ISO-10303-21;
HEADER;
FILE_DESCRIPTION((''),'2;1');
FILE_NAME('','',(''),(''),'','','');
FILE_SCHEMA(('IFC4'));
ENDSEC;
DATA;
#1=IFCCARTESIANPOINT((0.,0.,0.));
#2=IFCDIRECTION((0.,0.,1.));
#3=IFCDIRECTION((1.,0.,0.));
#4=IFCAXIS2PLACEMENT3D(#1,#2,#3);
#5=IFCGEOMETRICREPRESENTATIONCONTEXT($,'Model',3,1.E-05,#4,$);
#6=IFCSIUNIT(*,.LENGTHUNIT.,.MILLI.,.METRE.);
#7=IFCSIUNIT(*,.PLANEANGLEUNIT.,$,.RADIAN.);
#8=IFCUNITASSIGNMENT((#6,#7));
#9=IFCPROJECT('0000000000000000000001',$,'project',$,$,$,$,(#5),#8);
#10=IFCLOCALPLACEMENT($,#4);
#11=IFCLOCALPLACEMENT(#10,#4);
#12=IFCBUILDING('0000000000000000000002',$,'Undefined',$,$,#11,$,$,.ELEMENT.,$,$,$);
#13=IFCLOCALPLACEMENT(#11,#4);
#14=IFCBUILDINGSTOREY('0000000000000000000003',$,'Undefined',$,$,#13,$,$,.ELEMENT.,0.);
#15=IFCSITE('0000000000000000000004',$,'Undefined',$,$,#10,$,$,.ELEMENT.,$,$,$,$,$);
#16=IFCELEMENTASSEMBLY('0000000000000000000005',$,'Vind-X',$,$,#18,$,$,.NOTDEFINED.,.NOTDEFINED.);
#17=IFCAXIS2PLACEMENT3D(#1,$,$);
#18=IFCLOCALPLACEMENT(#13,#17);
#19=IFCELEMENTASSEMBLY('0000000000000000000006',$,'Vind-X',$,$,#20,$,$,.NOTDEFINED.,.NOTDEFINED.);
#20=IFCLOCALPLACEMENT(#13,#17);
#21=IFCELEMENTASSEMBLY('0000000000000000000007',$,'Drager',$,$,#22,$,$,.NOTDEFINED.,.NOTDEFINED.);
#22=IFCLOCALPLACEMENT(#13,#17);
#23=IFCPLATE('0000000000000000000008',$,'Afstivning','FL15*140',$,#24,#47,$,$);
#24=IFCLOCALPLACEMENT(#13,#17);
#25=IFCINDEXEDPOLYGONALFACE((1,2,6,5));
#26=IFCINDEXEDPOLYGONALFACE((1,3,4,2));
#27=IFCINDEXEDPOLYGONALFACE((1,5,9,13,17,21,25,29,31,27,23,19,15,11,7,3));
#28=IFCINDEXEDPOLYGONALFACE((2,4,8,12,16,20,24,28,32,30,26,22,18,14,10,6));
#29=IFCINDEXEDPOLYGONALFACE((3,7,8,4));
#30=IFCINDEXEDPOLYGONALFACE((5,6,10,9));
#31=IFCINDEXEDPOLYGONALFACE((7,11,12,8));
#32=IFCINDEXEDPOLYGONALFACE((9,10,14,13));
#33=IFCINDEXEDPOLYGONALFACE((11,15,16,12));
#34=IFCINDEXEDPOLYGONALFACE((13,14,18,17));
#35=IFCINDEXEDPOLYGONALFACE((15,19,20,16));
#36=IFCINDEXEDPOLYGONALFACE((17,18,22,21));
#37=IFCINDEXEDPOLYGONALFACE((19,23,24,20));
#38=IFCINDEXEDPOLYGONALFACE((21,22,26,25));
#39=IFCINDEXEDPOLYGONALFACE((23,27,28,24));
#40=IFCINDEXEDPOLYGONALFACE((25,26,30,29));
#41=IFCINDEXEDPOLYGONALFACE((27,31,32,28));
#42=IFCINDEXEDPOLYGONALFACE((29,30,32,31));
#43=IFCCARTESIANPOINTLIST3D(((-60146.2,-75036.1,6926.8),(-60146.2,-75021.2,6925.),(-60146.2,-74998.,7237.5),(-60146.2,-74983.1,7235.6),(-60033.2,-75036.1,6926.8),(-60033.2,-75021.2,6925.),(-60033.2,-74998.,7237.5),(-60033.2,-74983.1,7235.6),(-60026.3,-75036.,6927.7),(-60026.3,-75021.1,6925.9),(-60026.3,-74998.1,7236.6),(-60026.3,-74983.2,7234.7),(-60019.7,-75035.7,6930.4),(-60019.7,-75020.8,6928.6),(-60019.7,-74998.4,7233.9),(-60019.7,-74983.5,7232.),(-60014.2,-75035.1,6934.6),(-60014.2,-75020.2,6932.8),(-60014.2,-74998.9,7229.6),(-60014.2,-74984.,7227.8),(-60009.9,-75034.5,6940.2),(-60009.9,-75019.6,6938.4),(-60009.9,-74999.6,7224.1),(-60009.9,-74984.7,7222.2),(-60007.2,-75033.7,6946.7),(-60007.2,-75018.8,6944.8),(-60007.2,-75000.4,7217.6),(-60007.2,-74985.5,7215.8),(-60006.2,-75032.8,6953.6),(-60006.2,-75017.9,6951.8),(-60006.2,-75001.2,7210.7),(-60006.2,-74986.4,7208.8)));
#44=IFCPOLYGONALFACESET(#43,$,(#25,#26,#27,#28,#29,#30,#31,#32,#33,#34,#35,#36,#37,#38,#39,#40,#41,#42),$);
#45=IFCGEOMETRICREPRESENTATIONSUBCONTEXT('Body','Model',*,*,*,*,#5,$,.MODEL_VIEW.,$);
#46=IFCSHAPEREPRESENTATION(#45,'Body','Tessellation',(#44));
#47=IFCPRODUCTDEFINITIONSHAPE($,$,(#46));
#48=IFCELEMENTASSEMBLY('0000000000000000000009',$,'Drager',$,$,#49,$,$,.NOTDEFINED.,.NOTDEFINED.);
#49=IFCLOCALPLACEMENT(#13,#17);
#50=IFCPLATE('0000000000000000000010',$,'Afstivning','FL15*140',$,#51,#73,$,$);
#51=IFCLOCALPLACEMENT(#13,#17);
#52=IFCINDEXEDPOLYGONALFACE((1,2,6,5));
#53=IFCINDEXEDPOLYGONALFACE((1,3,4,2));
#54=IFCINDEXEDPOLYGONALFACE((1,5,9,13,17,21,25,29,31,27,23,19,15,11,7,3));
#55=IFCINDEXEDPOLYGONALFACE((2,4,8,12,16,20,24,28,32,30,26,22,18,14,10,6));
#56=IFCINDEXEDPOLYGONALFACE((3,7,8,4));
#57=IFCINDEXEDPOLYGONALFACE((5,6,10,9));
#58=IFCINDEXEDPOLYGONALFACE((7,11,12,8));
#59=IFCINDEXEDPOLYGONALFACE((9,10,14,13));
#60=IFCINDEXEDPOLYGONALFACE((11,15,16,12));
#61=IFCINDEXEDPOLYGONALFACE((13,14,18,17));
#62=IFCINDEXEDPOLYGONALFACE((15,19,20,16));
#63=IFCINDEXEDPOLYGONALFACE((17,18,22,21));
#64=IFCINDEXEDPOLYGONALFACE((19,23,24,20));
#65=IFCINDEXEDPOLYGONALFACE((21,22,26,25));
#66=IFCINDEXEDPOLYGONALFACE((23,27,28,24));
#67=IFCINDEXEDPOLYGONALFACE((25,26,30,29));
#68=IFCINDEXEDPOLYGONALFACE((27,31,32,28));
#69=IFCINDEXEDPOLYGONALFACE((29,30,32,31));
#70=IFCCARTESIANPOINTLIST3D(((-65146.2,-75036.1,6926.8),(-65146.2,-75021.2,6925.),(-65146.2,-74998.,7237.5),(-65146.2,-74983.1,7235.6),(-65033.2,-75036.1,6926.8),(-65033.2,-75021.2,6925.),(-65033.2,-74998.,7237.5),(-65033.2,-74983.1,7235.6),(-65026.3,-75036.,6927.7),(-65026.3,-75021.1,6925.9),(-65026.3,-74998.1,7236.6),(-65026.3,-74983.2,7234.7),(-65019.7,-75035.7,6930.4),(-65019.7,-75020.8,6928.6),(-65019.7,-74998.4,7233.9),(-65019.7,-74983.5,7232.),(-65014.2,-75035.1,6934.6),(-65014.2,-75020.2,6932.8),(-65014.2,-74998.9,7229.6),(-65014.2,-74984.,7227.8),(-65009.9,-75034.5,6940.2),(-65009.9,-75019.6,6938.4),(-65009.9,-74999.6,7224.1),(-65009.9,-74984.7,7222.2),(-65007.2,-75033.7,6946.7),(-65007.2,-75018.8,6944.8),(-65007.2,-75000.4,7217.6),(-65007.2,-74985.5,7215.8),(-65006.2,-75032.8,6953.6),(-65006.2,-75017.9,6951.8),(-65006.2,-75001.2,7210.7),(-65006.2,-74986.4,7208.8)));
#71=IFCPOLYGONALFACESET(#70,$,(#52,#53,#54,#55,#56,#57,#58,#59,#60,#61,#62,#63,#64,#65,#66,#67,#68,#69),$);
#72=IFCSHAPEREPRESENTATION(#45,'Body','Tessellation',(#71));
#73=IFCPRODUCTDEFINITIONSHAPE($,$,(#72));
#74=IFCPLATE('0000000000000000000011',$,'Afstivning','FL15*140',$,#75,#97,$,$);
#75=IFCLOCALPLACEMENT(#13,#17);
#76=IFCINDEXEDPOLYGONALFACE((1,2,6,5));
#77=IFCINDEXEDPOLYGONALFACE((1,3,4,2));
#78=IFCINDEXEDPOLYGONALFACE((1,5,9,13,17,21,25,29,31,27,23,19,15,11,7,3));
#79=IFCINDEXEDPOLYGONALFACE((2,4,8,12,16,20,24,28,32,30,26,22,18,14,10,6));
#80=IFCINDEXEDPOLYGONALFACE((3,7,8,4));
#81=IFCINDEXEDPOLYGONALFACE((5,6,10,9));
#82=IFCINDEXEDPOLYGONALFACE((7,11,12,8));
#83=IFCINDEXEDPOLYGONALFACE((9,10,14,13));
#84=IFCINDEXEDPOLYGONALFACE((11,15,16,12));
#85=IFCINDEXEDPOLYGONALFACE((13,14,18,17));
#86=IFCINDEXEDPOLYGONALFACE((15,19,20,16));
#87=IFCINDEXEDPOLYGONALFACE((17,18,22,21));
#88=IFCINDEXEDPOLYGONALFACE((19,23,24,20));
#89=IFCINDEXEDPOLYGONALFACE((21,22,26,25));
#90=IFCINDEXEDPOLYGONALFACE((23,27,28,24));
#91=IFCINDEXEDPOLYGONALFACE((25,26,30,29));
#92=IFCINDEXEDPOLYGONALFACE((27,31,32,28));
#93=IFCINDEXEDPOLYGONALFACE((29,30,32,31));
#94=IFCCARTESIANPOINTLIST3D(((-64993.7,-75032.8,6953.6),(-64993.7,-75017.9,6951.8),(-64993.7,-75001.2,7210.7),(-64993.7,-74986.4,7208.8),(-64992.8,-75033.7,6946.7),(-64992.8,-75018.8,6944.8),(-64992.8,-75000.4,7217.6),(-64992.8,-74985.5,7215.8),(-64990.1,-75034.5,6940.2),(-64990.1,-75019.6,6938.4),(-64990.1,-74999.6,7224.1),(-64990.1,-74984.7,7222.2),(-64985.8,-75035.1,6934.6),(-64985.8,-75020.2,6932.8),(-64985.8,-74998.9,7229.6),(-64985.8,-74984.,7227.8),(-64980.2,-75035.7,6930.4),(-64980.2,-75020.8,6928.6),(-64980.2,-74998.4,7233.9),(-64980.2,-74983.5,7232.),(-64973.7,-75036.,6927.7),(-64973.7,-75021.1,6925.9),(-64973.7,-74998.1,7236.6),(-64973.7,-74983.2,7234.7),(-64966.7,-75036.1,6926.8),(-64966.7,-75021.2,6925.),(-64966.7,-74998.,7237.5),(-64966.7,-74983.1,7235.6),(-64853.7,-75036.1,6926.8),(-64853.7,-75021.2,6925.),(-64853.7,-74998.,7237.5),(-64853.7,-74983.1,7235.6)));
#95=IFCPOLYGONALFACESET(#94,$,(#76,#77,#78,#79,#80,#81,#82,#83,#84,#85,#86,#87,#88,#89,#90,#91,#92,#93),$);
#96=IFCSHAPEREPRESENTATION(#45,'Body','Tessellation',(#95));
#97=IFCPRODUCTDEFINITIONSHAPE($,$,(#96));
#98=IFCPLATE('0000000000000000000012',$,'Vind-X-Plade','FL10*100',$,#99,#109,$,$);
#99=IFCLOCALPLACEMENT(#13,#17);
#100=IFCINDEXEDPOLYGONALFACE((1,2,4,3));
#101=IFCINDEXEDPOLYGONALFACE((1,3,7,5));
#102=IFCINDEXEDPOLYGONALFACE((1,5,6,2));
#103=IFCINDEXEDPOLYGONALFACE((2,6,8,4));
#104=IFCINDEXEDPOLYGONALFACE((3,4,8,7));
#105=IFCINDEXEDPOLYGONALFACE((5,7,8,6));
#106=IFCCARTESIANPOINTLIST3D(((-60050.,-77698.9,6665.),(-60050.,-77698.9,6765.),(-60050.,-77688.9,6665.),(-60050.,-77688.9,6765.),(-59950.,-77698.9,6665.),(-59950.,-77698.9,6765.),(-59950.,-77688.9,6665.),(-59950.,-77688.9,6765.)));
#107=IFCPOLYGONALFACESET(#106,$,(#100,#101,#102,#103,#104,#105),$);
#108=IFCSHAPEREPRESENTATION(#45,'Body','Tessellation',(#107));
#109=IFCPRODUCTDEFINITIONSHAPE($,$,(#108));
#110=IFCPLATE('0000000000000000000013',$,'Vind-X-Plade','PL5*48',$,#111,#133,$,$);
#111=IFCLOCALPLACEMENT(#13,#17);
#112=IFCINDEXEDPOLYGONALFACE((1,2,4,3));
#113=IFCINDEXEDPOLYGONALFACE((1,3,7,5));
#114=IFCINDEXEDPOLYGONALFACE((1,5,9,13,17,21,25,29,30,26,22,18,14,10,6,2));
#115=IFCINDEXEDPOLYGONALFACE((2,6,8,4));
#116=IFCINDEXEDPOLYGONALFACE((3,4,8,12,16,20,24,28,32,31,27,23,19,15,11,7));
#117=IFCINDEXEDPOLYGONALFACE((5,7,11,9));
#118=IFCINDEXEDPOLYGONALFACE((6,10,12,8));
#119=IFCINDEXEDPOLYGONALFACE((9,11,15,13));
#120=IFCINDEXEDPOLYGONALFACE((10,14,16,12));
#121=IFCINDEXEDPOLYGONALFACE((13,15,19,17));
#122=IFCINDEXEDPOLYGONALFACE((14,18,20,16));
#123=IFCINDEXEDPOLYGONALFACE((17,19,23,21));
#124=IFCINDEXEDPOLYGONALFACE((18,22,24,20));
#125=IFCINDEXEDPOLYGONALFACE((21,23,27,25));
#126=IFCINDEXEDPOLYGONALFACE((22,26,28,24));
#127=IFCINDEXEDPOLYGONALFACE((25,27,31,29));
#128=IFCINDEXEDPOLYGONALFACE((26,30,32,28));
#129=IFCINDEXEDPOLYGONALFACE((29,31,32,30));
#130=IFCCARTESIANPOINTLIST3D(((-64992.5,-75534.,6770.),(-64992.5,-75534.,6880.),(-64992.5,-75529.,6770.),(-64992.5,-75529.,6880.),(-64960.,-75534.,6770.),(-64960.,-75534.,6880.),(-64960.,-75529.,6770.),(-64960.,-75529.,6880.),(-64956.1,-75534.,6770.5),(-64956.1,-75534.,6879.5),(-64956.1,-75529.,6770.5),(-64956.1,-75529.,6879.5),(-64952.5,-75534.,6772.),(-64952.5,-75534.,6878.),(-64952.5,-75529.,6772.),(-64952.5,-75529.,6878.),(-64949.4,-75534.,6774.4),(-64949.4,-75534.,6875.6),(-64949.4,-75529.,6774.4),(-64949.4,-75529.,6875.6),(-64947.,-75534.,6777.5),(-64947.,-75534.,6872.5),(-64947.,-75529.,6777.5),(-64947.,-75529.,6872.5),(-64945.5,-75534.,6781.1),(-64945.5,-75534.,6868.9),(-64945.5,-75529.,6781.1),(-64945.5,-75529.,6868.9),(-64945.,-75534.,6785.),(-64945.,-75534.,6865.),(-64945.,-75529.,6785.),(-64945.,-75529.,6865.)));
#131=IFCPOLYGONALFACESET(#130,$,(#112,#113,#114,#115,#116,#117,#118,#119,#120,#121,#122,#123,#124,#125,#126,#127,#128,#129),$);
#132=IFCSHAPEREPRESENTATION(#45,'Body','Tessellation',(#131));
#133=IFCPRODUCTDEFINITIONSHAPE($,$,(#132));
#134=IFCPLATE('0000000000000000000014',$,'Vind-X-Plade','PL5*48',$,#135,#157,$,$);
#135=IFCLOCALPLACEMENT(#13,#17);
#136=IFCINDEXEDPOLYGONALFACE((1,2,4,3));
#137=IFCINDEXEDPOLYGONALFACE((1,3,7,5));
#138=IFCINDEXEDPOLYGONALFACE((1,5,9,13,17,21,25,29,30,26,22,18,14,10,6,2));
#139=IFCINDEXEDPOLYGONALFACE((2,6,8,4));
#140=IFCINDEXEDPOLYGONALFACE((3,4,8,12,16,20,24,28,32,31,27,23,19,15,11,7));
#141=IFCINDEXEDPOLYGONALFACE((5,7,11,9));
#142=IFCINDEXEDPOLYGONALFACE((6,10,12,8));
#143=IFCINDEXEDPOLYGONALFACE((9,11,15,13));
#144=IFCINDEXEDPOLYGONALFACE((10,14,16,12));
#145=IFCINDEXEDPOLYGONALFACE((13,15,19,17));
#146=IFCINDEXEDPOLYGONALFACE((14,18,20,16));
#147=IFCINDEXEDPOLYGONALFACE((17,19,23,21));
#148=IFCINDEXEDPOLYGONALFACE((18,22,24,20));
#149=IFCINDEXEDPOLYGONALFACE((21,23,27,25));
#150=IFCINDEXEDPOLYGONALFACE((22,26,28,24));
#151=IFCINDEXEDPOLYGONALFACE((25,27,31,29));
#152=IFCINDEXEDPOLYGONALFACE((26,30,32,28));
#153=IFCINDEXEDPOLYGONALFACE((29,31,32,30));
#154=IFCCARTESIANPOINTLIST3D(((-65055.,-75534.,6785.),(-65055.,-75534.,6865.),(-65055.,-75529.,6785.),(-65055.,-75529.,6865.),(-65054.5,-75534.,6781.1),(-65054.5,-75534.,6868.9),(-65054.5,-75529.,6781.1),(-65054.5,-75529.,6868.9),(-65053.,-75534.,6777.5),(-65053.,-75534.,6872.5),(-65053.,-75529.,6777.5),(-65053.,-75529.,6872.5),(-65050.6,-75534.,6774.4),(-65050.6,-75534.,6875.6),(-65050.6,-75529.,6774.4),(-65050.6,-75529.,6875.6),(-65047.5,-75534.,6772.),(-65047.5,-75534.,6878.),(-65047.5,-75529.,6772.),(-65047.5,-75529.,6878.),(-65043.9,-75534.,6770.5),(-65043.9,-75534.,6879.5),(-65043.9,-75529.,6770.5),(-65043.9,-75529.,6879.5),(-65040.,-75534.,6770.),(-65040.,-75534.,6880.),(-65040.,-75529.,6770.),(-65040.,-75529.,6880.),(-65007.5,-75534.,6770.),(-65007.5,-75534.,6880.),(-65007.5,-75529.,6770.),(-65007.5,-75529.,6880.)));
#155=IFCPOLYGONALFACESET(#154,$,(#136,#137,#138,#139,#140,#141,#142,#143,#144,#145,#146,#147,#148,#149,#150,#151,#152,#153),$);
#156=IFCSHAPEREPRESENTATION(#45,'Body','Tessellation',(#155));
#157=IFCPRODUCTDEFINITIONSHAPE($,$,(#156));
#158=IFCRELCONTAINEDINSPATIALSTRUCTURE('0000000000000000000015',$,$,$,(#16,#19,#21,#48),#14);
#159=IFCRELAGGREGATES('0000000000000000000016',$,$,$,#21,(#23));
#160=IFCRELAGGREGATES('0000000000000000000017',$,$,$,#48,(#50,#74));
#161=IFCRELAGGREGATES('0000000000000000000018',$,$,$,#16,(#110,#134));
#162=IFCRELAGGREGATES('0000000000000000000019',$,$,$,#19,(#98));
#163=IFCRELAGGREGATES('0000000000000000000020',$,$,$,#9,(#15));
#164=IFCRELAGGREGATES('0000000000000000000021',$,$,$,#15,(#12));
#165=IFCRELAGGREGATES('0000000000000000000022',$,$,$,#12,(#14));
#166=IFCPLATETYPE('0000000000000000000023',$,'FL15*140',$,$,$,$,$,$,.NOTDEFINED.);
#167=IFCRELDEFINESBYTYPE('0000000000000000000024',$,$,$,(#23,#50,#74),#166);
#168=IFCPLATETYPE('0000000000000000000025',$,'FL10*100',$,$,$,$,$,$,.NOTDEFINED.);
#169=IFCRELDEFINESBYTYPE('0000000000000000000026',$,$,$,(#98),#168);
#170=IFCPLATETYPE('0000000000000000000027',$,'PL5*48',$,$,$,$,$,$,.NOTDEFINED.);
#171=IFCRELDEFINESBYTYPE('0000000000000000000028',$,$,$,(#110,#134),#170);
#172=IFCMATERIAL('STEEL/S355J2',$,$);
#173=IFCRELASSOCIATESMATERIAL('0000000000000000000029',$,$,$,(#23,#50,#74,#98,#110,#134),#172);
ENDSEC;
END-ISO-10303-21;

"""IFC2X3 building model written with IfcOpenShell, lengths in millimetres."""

from ifc_helpers import new_model, si_unit, frame, frame_2d, origin_with_axes, place, context, subcontext, project, spatial, polyline, circle_curve, parameter, trimmed, segment, composite_curve, outline, extrude, material, type_object, element, aggregate, save


model = new_model("IFC2X3")

# Units and contexts
model_context = context("Model", 3, precision=1e-05, world=origin_with_axes())
body_context = subcontext(model_context, "Body", "Model", "MODEL_VIEW")
ifc_project = project(units=[si_unit("LENGTHUNIT", "METRE", prefix="MILLI"), si_unit("PLANEANGLEUNIT", "RADIAN")], contexts=[model_context])

# Site, building, storey
site_placement = place(None, origin_with_axes())
site = spatial("IfcSite", under=ifc_project, at=site_placement, Name="Undefined", CompositionType="ELEMENT")
building_placement = place(site_placement, origin_with_axes())
building = spatial("IfcBuilding", under=site, at=building_placement, Name="Undefined", CompositionType="ELEMENT")
storey_placement = place(building_placement, origin_with_axes())
storey = spatial("IfcBuildingStorey", under=building, at=storey_placement, Name="Undefined", CompositionType="ELEMENT", Elevation=0.0)

# Element assemblies
assembly_1_placement = place(storey_placement, origin_with_axes())
assembly_1 = element("IfcElementAssembly", 1, at=assembly_1_placement, inside=storey, Name="Vind-X", AssemblyPlace="NOTDEFINED", PredefinedType="NOTDEFINED")
assembly_2_placement = place(storey_placement, origin_with_axes())
assembly_2 = element("IfcElementAssembly", 2, at=assembly_2_placement, inside=storey, Name="Vind-X", AssemblyPlace="NOTDEFINED", PredefinedType="NOTDEFINED")

# Element assembly, plate
assembly_3_placement = place(storey_placement, origin_with_axes())
assembly_3 = element("IfcElementAssembly", 3, at=assembly_3_placement, inside=storey, Name="Drager", AssemblyPlace="NOTDEFINED", PredefinedType="NOTDEFINED")
ifc_material_1 = material(Name="STEEL/S355J2")
plate_type_1 = type_object("IfcPlateType", Name="FL15*140", PredefinedType="NOTDEFINED")
plate_1_placement = place(assembly_3_placement, frame((-60006.2, -75028.7, 6925.9), z_axis=(0.0, 0.992546, -0.121869), x_axis=(-1.0, 0.0, 0.0)))
plate_1 = element("IfcPlate", 4, at=plate_1_placement, type_object=plate_type_1, material=ifc_material_1, Name="Afstivning", Description="FL15*140", context=body_context, shape_type="SweptSolid", body=[
    extrude(outline(composite_curve([segment(trimmed(circle_curve(frame_2d((27.0, 27.0), x_axis=(-1.0, 0.0)), 27.0), [parameter(0.0)], [parameter(1.570796)], True, "PARAMETER"), True, "CONTINUOUS"), segment(polyline([(27.0, 0.0), (140.0, 0.0), (140.0, 313.0), (27.0, 313.0)]), True, "CONTINUOUS"), segment(trimmed(circle_curve(frame_2d((27.0, 286.0), x_axis=(0.0, 1.0)), 27.0), [parameter(0.0)], [parameter(1.570796)], True, "PARAMETER"), True, "CONTINUOUS"), segment(polyline([(0.0, 286.0), (0.0, 27.0)]), True, "CONTINUOUS")], self_intersect=True)), frame((0.0, 0.0, -7.5), z_axis=(0.0, 0.0, 1.0), x_axis=(1.0, 0.0, 0.0)), (0.0, 0.0, 1.0), 15.0),
])
aggregate(assembly_3, [plate_1])

# Element assembly, plates
assembly_4_placement = place(storey_placement, origin_with_axes())
assembly_4 = element("IfcElementAssembly", 5, at=assembly_4_placement, inside=storey, Name="Drager", AssemblyPlace="NOTDEFINED", PredefinedType="NOTDEFINED")
plate_2_placement = place(assembly_4_placement, frame((-65006.2, -75028.7, 6925.9), z_axis=(0.0, 0.992546, -0.121869), x_axis=(-1.0, 0.0, 0.0)))
plate_2 = element("IfcPlate", 6, at=plate_2_placement, type_object=plate_type_1, material=ifc_material_1, Name="Afstivning", Description="FL15*140", context=body_context, shape_type="SweptSolid", body=[
    extrude(outline(composite_curve([segment(trimmed(circle_curve(frame_2d((27.0, 27.0), x_axis=(-1.0, 0.0)), 27.0), [parameter(0.0)], [parameter(1.570796)], True, "PARAMETER"), True, "CONTINUOUS"), segment(polyline([(27.0, 0.0), (140.0, 0.0), (140.0, 313.0), (27.0, 313.0)]), True, "CONTINUOUS"), segment(trimmed(circle_curve(frame_2d((27.0, 286.0), x_axis=(0.0, 1.0)), 27.0), [parameter(0.0)], [parameter(1.570796)], True, "PARAMETER"), True, "CONTINUOUS"), segment(polyline([(0.0, 286.0), (0.0, 27.0)]), True, "CONTINUOUS")], self_intersect=True)), frame((0.0, 0.0, -7.5), z_axis=(0.0, 0.0, 1.0), x_axis=(1.0, 0.0, 0.0)), (0.0, 0.0, 1.0), 15.0),
])
plate_3_placement = place(assembly_4_placement, frame((-64853.7, -75028.7, 6925.9), z_axis=(0.0, 0.992546, -0.121869), x_axis=(-1.0, 0.0, 0.0)))
plate_3 = element("IfcPlate", 7, at=plate_3_placement, type_object=plate_type_1, material=ifc_material_1, Name="Afstivning", Description="FL15*140", context=body_context, shape_type="SweptSolid", body=[
    extrude(outline(composite_curve([segment(polyline([(0.0, 0.0), (113.0, 0.0)]), True, "CONTINUOUS"), segment(trimmed(circle_curve(frame_2d((113.0, 27.0), x_axis=(0.0, -1.0)), 27.0), [parameter(0.0)], [parameter(1.570796)], True, "PARAMETER"), True, "CONTINUOUS"), segment(polyline([(140.0, 27.0), (140.0, 286.0)]), True, "CONTINUOUS"), segment(trimmed(circle_curve(frame_2d((113.0, 286.0), x_axis=(1.0, 0.0)), 27.0), [parameter(0.0)], [parameter(1.570796)], True, "PARAMETER"), True, "CONTINUOUS"), segment(polyline([(113.0, 313.0), (0.0, 313.0), (0.0, 0.0)]), True, "CONTINUOUS")], self_intersect=True)), frame((0.0, 0.0, -7.5), z_axis=(0.0, 0.0, 1.0), x_axis=(1.0, 0.0, 0.0)), (0.0, 0.0, 1.0), 15.0),
])
aggregate(assembly_4, [plate_2, plate_3])

# Plates
plate_type_2 = type_object("IfcPlateType", Name="FL10*100", PredefinedType="NOTDEFINED")
plate_4_placement = place(assembly_2_placement, frame((-60050.0, -77693.9, 6765.0), z_axis=(0.0, 1.0, 0.0), x_axis=(1.0, 0.0, 0.0)))
plate_4 = element("IfcPlate", 8, at=plate_4_placement, type_object=plate_type_2, material=ifc_material_1, Name="Vind-X-Plade", Description="FL10*100", context=body_context, shape_type="SweptSolid", body=[
    extrude(outline(polyline([(0.0, 0.0), (100.0, 0.0), (100.0, 100.0), (0.0, 100.0), (0.0, 0.0)])), frame((0.0, 0.0, -5.0), z_axis=(0.0, 0.0, 1.0), x_axis=(1.0, 0.0, 0.0)), (0.0, 0.0, 1.0), 10.0),
])
plate_type_3 = type_object("IfcPlateType", Name="PL5*48", PredefinedType="NOTDEFINED")
plate_5_placement = place(assembly_1_placement, frame((-64945.0, -75531.5, 6880.0), z_axis=(0.0, -1.0, 0.0), x_axis=(-1.0, 0.0, 0.0)))
plate_5 = element("IfcPlate", 9, at=plate_5_placement, type_object=plate_type_3, material=ifc_material_1, Name="Vind-X-Plade", Description="PL5*48", context=body_context, shape_type="SweptSolid", body=[
    extrude(outline(composite_curve([segment(trimmed(circle_curve(frame_2d((15.0, 15.0), x_axis=(-1.0, 0.0)), 15.0), [parameter(0.0)], [parameter(1.570796)], True, "PARAMETER"), True, "CONTINUOUS"), segment(polyline([(15.0, 0.0), (47.5, 0.0), (47.5, 110.0), (15.0, 110.0)]), True, "CONTINUOUS"), segment(trimmed(circle_curve(frame_2d((15.0, 95.0), x_axis=(0.0, 1.0)), 15.0), [parameter(0.0)], [parameter(1.570796)], True, "PARAMETER"), True, "CONTINUOUS"), segment(polyline([(0.0, 95.0), (0.0, 15.0)]), True, "CONTINUOUS")], self_intersect=True)), frame((0.0, 0.0, -2.5), z_axis=(0.0, 0.0, 1.0), x_axis=(1.0, 0.0, 0.0)), (0.0, 0.0, 1.0), 5.0),
])
plate_6_placement = place(assembly_1_placement, frame((-65007.5, -75531.5, 6880.0), z_axis=(0.0, -1.0, 0.0), x_axis=(-1.0, 0.0, 0.0)))
plate_6 = element("IfcPlate", 10, at=plate_6_placement, type_object=plate_type_3, material=ifc_material_1, Name="Vind-X-Plade", Description="PL5*48", context=body_context, shape_type="SweptSolid", body=[
    extrude(outline(composite_curve([segment(polyline([(0.0, 0.0), (32.5, 0.0)]), True, "CONTINUOUS"), segment(trimmed(circle_curve(frame_2d((32.5, 15.0), x_axis=(0.0, -1.0)), 15.0), [parameter(0.0)], [parameter(1.570796)], True, "PARAMETER"), True, "CONTINUOUS"), segment(polyline([(47.5, 15.0), (47.5, 95.0)]), True, "CONTINUOUS"), segment(trimmed(circle_curve(frame_2d((32.5, 95.0), x_axis=(1.0, 0.0)), 15.0), [parameter(0.0)], [parameter(1.570796)], True, "PARAMETER"), True, "CONTINUOUS"), segment(polyline([(32.5, 110.0), (0.0, 110.0), (0.0, 0.0)]), True, "CONTINUOUS")], self_intersect=True)), frame((0.0, 0.0, -2.5), z_axis=(0.0, 0.0, 1.0), x_axis=(1.0, 0.0, 0.0)), (0.0, 0.0, 1.0), 5.0),
])
aggregate(assembly_1, [plate_5, plate_6])
aggregate(assembly_2, [plate_4])

save(model, "model.ifc")
